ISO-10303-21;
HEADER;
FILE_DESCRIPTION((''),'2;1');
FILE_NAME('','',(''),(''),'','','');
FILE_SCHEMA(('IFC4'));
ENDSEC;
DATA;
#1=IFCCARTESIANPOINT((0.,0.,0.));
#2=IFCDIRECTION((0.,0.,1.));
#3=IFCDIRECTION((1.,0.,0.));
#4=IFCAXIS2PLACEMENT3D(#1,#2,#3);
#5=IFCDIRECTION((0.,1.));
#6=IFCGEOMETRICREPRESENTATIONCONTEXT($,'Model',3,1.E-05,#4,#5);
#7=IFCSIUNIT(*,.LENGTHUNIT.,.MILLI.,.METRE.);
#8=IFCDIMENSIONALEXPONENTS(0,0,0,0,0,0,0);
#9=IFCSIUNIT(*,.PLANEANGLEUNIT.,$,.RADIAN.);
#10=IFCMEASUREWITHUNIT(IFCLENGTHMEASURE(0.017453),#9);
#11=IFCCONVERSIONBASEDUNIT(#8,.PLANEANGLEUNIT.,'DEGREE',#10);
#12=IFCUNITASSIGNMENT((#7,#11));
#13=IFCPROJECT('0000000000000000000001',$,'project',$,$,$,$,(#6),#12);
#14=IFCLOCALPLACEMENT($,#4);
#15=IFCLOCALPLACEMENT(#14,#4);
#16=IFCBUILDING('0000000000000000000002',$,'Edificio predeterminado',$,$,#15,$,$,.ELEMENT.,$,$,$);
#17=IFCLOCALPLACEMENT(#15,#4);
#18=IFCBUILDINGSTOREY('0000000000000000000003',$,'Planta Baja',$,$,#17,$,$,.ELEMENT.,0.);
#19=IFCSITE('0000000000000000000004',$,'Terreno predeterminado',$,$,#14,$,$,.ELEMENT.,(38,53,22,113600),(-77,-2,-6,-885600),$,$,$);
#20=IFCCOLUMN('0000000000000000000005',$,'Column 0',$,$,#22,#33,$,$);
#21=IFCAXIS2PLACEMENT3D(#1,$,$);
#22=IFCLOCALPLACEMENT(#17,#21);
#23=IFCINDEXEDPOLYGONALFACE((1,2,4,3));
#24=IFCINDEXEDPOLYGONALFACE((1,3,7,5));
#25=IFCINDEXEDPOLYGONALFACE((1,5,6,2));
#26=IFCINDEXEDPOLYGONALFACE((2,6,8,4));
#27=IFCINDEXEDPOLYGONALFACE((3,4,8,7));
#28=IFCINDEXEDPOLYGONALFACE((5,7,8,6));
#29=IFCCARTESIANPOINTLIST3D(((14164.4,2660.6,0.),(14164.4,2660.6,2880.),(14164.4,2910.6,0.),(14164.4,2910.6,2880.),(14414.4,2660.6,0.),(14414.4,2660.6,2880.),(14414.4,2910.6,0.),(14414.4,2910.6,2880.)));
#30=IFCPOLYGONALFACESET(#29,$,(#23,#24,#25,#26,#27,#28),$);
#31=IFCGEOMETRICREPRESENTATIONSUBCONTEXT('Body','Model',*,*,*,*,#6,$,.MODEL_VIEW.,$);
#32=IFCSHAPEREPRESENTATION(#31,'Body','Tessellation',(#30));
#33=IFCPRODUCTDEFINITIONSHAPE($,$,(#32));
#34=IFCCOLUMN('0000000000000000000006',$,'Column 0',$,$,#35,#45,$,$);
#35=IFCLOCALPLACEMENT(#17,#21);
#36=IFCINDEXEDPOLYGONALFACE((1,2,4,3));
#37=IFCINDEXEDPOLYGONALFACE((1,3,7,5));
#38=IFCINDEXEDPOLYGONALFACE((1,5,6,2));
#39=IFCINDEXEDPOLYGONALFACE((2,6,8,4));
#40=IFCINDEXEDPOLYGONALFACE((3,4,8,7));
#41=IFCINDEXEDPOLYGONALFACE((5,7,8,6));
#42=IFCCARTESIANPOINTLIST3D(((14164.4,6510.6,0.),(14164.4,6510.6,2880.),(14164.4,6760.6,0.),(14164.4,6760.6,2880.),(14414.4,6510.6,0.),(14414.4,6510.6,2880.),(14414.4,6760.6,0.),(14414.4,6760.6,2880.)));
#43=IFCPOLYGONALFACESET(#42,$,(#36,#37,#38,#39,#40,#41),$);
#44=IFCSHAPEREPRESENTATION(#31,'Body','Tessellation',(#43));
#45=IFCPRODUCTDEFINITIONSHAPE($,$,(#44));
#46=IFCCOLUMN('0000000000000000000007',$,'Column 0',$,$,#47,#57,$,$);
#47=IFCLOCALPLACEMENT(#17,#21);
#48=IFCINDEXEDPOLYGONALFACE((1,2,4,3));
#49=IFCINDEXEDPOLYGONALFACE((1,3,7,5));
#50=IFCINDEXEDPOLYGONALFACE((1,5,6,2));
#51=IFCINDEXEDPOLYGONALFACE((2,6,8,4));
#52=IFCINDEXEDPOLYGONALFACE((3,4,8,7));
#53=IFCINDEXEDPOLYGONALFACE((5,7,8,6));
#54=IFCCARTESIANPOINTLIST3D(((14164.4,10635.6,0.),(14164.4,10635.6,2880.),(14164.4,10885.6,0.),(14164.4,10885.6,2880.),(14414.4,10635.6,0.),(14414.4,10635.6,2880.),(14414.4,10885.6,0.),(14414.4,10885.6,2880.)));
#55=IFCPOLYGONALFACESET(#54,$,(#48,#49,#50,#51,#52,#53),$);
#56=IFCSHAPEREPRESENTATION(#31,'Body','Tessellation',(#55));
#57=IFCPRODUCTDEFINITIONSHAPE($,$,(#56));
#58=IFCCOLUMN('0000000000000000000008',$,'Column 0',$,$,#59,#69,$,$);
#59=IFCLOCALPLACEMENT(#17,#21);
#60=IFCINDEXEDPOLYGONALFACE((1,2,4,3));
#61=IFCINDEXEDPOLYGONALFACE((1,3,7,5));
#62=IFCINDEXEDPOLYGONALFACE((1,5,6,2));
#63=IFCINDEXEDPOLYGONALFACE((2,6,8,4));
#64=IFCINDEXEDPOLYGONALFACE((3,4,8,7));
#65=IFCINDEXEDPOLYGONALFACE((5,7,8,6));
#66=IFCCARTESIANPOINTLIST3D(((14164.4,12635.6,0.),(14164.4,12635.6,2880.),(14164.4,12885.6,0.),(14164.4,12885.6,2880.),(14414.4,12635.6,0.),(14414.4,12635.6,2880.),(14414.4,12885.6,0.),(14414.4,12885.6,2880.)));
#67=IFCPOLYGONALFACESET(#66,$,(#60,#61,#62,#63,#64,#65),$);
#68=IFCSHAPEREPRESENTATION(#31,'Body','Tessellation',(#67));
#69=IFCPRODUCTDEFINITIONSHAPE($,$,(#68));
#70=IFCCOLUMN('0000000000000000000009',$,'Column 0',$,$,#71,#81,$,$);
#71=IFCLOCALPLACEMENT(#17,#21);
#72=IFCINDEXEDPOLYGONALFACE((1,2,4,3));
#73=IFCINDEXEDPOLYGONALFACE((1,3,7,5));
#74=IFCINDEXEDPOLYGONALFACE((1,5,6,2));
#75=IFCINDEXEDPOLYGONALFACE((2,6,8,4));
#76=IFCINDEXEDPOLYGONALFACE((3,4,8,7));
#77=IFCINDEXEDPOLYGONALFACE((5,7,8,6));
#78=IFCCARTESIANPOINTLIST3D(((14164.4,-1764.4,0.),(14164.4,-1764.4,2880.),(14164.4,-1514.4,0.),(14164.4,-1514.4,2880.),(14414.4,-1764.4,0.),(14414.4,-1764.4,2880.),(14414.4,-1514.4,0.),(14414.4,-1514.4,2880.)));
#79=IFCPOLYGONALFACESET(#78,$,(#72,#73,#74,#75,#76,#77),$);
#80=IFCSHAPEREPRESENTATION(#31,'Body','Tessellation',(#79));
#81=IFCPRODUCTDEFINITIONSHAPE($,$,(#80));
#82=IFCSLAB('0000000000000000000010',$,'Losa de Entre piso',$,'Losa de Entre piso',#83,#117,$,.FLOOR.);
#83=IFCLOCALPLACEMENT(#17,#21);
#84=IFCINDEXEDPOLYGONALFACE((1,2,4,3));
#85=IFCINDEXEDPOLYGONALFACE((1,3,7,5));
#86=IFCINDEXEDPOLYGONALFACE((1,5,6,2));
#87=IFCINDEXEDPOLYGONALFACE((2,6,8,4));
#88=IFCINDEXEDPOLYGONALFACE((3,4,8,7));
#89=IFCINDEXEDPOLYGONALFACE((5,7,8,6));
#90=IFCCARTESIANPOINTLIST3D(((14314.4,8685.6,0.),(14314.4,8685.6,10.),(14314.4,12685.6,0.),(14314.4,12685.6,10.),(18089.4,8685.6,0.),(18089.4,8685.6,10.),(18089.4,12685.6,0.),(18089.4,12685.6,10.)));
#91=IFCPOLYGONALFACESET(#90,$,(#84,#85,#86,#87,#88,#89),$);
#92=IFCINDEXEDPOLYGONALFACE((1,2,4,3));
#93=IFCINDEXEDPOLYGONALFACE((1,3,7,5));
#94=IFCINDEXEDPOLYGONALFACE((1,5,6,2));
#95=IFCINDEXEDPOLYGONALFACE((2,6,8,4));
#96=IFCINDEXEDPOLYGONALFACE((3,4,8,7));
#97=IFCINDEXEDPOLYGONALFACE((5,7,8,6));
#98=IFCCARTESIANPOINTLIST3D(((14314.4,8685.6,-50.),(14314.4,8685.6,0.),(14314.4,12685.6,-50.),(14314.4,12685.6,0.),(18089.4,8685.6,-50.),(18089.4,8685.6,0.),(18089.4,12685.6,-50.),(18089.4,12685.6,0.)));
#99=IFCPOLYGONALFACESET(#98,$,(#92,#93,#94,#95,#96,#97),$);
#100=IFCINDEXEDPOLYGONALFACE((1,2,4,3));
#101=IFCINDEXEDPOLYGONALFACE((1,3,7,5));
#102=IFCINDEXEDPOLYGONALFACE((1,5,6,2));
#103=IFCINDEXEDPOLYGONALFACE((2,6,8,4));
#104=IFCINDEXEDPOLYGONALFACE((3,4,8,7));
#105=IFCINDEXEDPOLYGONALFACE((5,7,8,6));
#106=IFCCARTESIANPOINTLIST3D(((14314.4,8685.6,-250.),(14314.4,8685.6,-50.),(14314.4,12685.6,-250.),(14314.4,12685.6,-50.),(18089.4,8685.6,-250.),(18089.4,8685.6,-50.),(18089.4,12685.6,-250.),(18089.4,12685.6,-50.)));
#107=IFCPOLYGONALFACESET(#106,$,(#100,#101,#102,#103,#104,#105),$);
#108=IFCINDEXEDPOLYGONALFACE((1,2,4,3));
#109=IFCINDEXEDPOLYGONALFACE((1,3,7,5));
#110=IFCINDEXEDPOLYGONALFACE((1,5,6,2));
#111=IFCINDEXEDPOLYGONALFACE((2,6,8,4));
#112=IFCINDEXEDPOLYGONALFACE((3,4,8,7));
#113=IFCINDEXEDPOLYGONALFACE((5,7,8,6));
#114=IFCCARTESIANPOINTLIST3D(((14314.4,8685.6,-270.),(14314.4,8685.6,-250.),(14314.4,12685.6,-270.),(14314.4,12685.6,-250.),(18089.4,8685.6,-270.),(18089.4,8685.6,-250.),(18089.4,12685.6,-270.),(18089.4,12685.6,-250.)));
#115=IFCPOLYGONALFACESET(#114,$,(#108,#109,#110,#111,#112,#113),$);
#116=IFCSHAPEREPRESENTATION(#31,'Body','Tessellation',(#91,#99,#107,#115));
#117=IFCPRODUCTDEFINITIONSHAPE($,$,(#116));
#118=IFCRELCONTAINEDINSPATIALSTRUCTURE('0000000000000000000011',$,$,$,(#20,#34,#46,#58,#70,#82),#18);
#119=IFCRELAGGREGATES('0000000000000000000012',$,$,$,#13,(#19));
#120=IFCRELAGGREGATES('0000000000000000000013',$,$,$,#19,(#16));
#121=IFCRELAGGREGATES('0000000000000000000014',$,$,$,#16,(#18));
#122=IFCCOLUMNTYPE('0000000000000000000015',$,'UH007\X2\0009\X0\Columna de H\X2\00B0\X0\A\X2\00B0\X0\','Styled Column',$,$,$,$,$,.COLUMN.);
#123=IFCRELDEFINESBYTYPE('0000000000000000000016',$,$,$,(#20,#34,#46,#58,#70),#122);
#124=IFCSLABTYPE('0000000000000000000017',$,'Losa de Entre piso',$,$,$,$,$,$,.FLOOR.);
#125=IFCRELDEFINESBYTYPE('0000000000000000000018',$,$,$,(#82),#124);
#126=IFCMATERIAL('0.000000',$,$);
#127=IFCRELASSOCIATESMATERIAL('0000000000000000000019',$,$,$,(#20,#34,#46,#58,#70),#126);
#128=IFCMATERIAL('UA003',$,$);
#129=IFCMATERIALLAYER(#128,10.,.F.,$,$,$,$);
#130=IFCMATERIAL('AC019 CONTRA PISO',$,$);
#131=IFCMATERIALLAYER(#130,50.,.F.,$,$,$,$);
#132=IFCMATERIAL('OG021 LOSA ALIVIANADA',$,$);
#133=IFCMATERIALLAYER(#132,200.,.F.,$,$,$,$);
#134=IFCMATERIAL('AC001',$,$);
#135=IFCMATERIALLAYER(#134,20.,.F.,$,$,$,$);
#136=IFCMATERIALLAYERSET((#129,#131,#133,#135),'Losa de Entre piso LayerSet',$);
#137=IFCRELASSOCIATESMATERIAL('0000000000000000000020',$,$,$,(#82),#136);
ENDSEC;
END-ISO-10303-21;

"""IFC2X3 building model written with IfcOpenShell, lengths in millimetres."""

from ifc_helpers import new_model, entity, si_unit, converted_unit, direction, frame, origin_with_axes, place, context, subcontext, project, spatial, polyline, outline, extrude, material, layer, layer_set, layer_usage, type_object, element, save


model = new_model("IFC2X3")

# Units and contexts
model_context = context("Model", 3, precision=1e-05, world=origin_with_axes(), true_north=direction((0.0, 1.0)))
body_context = subcontext(model_context, "Body", "Model", "MODEL_VIEW")
ifc_project = project(units=[si_unit("LENGTHUNIT", "METRE", prefix="MILLI"), converted_unit("PLANEANGLEUNIT", "DEGREE", entity("IfcLengthMeasure", 0.017453), si_unit("PLANEANGLEUNIT", "RADIAN"), dimensions=[0, 0, 0, 0, 0, 0, 0])], contexts=[model_context])

# Site, building, storey
site_placement = place(None, origin_with_axes())
site = spatial("IfcSite", under=ifc_project, at=site_placement, Name="Terreno predeterminado", CompositionType="ELEMENT", RefLatitude=(38, 53, 22, 113600), RefLongitude=(-77, -2, -6, -885600))
building_placement = place(site_placement, origin_with_axes())
building = spatial("IfcBuilding", under=site, at=building_placement, Name="Edificio predeterminado", CompositionType="ELEMENT")
storey_placement = place(building_placement, origin_with_axes())
storey = spatial("IfcBuildingStorey", under=building, at=storey_placement, Name="Planta Baja", CompositionType="ELEMENT", Elevation=0.0)

# Columns
ifc_material_1 = material(Name="0.000000")
column_type = type_object("IfcColumnType", Name="UH007\tColumna de H°A°", Description="Styled Column", PredefinedType="COLUMN")
for number, where, z_axis, x_axis, name in (
    (1, (14289.4, 2785.6, 0.0), (0.0, 0.0, 1.0), (1.0, 0.0, 0.0), "Column 0"),
    (2, (14289.4, 6635.6, 0.0), (0.0, 0.0, 1.0), (1.0, 0.0, 0.0), "Column 0"),
    (3, (14289.4, 10760.6, 0.0), (0.0, 0.0, 1.0), (1.0, 0.0, 0.0), "Column 0"),
    (4, (14289.4, 12760.6, 0.0), (0.0, 0.0, 1.0), (1.0, 0.0, 0.0), "Column 0"),
    (5, (14289.4, -1639.4, 0.0), (0.0, 0.0, 1.0), (1.0, 0.0, 0.0), "Column 0"),
):
    element("IfcColumn", number, at=place(storey_placement, frame(where, z_axis=z_axis, x_axis=x_axis)), inside=storey, type_object=column_type, material=ifc_material_1, Name=name, context=body_context, shape_type="SweptSolid", body=[
        extrude(outline(polyline([(-125.0, -125.0), (125.0, -125.0), (125.0, 125.0), (-125.0, 125.0), (-125.0, -125.0)])), origin_with_axes(), (0.0, 0.0, 1.0), 2880.0),
    ])

# Slab
ifc_material_2 = material(Name="UA003")
ifc_layer_1 = layer(ifc_material_2, 10.0, ventilated=False)
ifc_material_3 = material(Name="AC019 CONTRA PISO")
ifc_layer_2 = layer(ifc_material_3, 50.0, ventilated=False)
ifc_material_4 = material(Name="OG021 LOSA ALIVIANADA")
ifc_layer_3 = layer(ifc_material_4, 200.0, ventilated=False)
ifc_material_5 = material(Name="AC001")
ifc_layer_4 = layer(ifc_material_5, 20.0, ventilated=False)
ifc_layer_set_1 = layer_set([ifc_layer_1, ifc_layer_2, ifc_layer_3, ifc_layer_4], Name="Losa de Entre piso LayerSet")
ifc_layer_usage_1 = layer_usage(ifc_layer_set_1, "AXIS3", "NEGATIVE", 0.0)
slab_type = type_object("IfcSlabType", Name="Losa de Entre piso", PredefinedType="FLOOR")
slab_1_placement = place(storey_placement, origin_with_axes())
element("IfcSlab", 6, at=slab_1_placement, inside=storey, type_object=slab_type, material=ifc_layer_usage_1, Name="Losa de Entre piso", ObjectType="Losa de Entre piso", PredefinedType="FLOOR", context=body_context, shape_type="SweptSolid", body=[
    extrude(outline(polyline([(0.0, 4000.0), (3775.0, 4000.0), (3775.0, 0.0), (0.0, 0.0), (0.0, 4000.0)])), frame((14314.4, 12685.6, 0.0), z_axis=(0.0, 0.0, -1.0), x_axis=(1.0, 0.0, 0.0)), (0.0, 0.0, -1.0), 10.0),
    extrude(outline(polyline([(0.0, 4000.0), (3775.0, 4000.0), (3775.0, 0.0), (0.0, 0.0), (0.0, 4000.0)])), frame((14314.4, 12685.6, -50.0), z_axis=(0.0, 0.0, -1.0), x_axis=(1.0, 0.0, 0.0)), (0.0, 0.0, -1.0), 50.0),
    extrude(outline(polyline([(0.0, 4000.0), (3775.0, 4000.0), (3775.0, 0.0), (0.0, 0.0), (0.0, 4000.0)])), frame((14314.4, 12685.6, -250.0), z_axis=(0.0, 0.0, -1.0), x_axis=(1.0, 0.0, 0.0)), (0.0, 0.0, -1.0), 200.0),
    extrude(outline(polyline([(0.0, 4000.0), (3775.0, 4000.0), (3775.0, 0.0), (0.0, 0.0), (0.0, 4000.0)])), frame((14314.4, 12685.6, -270.0), z_axis=(0.0, 0.0, -1.0), x_axis=(1.0, 0.0, 0.0)), (0.0, 0.0, -1.0), 20.0),
])

save(model, "model.ifc")
